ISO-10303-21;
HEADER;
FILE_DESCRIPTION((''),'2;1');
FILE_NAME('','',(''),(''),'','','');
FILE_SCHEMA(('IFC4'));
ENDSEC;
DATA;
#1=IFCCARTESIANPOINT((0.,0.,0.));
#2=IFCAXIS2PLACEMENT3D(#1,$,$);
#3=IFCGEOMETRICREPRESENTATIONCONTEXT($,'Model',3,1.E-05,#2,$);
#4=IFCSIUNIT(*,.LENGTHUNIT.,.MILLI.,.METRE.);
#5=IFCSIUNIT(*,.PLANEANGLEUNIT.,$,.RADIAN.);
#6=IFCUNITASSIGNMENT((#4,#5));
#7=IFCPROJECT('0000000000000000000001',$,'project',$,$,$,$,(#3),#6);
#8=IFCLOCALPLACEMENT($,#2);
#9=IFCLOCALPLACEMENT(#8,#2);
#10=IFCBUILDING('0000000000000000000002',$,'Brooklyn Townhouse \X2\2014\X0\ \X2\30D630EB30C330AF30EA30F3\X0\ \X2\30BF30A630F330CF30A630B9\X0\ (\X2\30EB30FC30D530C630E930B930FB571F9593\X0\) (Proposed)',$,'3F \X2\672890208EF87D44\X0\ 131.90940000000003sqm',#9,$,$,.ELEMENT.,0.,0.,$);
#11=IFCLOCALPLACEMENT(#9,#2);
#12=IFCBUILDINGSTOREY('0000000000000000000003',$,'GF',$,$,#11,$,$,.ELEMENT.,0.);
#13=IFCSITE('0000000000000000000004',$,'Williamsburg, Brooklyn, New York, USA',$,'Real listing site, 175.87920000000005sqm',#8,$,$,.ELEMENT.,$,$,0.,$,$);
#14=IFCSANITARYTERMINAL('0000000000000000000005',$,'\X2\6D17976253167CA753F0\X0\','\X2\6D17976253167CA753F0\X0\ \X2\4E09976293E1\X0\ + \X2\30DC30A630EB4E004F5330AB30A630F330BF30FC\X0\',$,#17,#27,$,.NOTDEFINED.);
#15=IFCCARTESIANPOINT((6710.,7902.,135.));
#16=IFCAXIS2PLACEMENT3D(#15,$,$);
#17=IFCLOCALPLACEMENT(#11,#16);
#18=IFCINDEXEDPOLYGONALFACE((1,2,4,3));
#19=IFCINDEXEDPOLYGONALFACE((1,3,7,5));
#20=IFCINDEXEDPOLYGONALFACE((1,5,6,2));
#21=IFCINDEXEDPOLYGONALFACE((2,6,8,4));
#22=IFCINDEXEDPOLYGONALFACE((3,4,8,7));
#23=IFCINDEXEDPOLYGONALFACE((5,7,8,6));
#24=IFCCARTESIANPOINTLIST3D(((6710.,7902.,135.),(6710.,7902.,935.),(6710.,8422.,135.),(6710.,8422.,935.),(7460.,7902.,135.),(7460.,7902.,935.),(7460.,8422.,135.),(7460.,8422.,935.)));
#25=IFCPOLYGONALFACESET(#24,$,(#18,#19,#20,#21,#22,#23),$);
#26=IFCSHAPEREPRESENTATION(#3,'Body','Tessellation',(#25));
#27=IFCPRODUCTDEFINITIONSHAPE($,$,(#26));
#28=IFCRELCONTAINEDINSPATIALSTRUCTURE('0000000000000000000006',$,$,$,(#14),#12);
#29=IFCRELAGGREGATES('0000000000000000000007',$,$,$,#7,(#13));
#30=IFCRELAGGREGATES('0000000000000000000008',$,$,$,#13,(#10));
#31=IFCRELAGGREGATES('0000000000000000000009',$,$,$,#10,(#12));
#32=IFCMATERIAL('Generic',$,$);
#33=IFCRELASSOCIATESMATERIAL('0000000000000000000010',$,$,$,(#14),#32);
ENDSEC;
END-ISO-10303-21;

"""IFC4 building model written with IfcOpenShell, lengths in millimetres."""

from ifc_helpers import new_model, si_unit, frame, frame_2d, origin, place, context, project, spatial, rectangle, extrude, material, element, save


model = new_model("IFC4")

# Units and contexts
model_context = context("Model", 3, precision=1e-05, world=origin())
ifc_project = project(units=[si_unit("LENGTHUNIT", "METRE", prefix="MILLI"), si_unit("PLANEANGLEUNIT", "RADIAN")], contexts=[model_context])

# Site, building, storey
site_placement = place(None, origin())
site = spatial("IfcSite", under=ifc_project, at=site_placement, Name="Williamsburg, Brooklyn, New York, USA", ObjectType="Real listing site, 175.87920000000005sqm", CompositionType="ELEMENT", RefElevation=0.0)
building_placement = place(site_placement, origin())
building = spatial("IfcBuilding", under=site, at=building_placement, Name="Brooklyn Townhouse — ブルックリン タウンハウス (ルーフテラス・土間) (Proposed)", ObjectType="3F 木造軸組 131.90940000000003sqm", CompositionType="ELEMENT", ElevationOfRefHeight=0.0, ElevationOfTerrain=0.0)
storey_placement = place(building_placement, origin())
storey = spatial("IfcBuildingStorey", under=building, at=storey_placement, Name="GF", CompositionType="ELEMENT", Elevation=0.0)

# Shared definitions
ifc_material_1 = material(Name="Generic")

# Sanitary terminal
sanitary_terminal_1_placement = place(storey_placement, frame((6710.0, 7902.0, 135.0)))
element("IfcSanitaryTerminal", 1, at=sanitary_terminal_1_placement, inside=storey, material=ifc_material_1, Name="洗面化粧台", Description="洗面化粧台 三面鏡 + ボウル一体カウンター", PredefinedType="NOTDEFINED", context=model_context, shape_type="SweptSolid", body=[
    extrude(rectangle(XDim=750.0, YDim=520.0, at=frame_2d((375.0, 260.0))), frame((6710.0, 7902.0, 135.0)), (0.0, 0.0, 1.0), 800.0),
])

save(model, "model.ifc")
